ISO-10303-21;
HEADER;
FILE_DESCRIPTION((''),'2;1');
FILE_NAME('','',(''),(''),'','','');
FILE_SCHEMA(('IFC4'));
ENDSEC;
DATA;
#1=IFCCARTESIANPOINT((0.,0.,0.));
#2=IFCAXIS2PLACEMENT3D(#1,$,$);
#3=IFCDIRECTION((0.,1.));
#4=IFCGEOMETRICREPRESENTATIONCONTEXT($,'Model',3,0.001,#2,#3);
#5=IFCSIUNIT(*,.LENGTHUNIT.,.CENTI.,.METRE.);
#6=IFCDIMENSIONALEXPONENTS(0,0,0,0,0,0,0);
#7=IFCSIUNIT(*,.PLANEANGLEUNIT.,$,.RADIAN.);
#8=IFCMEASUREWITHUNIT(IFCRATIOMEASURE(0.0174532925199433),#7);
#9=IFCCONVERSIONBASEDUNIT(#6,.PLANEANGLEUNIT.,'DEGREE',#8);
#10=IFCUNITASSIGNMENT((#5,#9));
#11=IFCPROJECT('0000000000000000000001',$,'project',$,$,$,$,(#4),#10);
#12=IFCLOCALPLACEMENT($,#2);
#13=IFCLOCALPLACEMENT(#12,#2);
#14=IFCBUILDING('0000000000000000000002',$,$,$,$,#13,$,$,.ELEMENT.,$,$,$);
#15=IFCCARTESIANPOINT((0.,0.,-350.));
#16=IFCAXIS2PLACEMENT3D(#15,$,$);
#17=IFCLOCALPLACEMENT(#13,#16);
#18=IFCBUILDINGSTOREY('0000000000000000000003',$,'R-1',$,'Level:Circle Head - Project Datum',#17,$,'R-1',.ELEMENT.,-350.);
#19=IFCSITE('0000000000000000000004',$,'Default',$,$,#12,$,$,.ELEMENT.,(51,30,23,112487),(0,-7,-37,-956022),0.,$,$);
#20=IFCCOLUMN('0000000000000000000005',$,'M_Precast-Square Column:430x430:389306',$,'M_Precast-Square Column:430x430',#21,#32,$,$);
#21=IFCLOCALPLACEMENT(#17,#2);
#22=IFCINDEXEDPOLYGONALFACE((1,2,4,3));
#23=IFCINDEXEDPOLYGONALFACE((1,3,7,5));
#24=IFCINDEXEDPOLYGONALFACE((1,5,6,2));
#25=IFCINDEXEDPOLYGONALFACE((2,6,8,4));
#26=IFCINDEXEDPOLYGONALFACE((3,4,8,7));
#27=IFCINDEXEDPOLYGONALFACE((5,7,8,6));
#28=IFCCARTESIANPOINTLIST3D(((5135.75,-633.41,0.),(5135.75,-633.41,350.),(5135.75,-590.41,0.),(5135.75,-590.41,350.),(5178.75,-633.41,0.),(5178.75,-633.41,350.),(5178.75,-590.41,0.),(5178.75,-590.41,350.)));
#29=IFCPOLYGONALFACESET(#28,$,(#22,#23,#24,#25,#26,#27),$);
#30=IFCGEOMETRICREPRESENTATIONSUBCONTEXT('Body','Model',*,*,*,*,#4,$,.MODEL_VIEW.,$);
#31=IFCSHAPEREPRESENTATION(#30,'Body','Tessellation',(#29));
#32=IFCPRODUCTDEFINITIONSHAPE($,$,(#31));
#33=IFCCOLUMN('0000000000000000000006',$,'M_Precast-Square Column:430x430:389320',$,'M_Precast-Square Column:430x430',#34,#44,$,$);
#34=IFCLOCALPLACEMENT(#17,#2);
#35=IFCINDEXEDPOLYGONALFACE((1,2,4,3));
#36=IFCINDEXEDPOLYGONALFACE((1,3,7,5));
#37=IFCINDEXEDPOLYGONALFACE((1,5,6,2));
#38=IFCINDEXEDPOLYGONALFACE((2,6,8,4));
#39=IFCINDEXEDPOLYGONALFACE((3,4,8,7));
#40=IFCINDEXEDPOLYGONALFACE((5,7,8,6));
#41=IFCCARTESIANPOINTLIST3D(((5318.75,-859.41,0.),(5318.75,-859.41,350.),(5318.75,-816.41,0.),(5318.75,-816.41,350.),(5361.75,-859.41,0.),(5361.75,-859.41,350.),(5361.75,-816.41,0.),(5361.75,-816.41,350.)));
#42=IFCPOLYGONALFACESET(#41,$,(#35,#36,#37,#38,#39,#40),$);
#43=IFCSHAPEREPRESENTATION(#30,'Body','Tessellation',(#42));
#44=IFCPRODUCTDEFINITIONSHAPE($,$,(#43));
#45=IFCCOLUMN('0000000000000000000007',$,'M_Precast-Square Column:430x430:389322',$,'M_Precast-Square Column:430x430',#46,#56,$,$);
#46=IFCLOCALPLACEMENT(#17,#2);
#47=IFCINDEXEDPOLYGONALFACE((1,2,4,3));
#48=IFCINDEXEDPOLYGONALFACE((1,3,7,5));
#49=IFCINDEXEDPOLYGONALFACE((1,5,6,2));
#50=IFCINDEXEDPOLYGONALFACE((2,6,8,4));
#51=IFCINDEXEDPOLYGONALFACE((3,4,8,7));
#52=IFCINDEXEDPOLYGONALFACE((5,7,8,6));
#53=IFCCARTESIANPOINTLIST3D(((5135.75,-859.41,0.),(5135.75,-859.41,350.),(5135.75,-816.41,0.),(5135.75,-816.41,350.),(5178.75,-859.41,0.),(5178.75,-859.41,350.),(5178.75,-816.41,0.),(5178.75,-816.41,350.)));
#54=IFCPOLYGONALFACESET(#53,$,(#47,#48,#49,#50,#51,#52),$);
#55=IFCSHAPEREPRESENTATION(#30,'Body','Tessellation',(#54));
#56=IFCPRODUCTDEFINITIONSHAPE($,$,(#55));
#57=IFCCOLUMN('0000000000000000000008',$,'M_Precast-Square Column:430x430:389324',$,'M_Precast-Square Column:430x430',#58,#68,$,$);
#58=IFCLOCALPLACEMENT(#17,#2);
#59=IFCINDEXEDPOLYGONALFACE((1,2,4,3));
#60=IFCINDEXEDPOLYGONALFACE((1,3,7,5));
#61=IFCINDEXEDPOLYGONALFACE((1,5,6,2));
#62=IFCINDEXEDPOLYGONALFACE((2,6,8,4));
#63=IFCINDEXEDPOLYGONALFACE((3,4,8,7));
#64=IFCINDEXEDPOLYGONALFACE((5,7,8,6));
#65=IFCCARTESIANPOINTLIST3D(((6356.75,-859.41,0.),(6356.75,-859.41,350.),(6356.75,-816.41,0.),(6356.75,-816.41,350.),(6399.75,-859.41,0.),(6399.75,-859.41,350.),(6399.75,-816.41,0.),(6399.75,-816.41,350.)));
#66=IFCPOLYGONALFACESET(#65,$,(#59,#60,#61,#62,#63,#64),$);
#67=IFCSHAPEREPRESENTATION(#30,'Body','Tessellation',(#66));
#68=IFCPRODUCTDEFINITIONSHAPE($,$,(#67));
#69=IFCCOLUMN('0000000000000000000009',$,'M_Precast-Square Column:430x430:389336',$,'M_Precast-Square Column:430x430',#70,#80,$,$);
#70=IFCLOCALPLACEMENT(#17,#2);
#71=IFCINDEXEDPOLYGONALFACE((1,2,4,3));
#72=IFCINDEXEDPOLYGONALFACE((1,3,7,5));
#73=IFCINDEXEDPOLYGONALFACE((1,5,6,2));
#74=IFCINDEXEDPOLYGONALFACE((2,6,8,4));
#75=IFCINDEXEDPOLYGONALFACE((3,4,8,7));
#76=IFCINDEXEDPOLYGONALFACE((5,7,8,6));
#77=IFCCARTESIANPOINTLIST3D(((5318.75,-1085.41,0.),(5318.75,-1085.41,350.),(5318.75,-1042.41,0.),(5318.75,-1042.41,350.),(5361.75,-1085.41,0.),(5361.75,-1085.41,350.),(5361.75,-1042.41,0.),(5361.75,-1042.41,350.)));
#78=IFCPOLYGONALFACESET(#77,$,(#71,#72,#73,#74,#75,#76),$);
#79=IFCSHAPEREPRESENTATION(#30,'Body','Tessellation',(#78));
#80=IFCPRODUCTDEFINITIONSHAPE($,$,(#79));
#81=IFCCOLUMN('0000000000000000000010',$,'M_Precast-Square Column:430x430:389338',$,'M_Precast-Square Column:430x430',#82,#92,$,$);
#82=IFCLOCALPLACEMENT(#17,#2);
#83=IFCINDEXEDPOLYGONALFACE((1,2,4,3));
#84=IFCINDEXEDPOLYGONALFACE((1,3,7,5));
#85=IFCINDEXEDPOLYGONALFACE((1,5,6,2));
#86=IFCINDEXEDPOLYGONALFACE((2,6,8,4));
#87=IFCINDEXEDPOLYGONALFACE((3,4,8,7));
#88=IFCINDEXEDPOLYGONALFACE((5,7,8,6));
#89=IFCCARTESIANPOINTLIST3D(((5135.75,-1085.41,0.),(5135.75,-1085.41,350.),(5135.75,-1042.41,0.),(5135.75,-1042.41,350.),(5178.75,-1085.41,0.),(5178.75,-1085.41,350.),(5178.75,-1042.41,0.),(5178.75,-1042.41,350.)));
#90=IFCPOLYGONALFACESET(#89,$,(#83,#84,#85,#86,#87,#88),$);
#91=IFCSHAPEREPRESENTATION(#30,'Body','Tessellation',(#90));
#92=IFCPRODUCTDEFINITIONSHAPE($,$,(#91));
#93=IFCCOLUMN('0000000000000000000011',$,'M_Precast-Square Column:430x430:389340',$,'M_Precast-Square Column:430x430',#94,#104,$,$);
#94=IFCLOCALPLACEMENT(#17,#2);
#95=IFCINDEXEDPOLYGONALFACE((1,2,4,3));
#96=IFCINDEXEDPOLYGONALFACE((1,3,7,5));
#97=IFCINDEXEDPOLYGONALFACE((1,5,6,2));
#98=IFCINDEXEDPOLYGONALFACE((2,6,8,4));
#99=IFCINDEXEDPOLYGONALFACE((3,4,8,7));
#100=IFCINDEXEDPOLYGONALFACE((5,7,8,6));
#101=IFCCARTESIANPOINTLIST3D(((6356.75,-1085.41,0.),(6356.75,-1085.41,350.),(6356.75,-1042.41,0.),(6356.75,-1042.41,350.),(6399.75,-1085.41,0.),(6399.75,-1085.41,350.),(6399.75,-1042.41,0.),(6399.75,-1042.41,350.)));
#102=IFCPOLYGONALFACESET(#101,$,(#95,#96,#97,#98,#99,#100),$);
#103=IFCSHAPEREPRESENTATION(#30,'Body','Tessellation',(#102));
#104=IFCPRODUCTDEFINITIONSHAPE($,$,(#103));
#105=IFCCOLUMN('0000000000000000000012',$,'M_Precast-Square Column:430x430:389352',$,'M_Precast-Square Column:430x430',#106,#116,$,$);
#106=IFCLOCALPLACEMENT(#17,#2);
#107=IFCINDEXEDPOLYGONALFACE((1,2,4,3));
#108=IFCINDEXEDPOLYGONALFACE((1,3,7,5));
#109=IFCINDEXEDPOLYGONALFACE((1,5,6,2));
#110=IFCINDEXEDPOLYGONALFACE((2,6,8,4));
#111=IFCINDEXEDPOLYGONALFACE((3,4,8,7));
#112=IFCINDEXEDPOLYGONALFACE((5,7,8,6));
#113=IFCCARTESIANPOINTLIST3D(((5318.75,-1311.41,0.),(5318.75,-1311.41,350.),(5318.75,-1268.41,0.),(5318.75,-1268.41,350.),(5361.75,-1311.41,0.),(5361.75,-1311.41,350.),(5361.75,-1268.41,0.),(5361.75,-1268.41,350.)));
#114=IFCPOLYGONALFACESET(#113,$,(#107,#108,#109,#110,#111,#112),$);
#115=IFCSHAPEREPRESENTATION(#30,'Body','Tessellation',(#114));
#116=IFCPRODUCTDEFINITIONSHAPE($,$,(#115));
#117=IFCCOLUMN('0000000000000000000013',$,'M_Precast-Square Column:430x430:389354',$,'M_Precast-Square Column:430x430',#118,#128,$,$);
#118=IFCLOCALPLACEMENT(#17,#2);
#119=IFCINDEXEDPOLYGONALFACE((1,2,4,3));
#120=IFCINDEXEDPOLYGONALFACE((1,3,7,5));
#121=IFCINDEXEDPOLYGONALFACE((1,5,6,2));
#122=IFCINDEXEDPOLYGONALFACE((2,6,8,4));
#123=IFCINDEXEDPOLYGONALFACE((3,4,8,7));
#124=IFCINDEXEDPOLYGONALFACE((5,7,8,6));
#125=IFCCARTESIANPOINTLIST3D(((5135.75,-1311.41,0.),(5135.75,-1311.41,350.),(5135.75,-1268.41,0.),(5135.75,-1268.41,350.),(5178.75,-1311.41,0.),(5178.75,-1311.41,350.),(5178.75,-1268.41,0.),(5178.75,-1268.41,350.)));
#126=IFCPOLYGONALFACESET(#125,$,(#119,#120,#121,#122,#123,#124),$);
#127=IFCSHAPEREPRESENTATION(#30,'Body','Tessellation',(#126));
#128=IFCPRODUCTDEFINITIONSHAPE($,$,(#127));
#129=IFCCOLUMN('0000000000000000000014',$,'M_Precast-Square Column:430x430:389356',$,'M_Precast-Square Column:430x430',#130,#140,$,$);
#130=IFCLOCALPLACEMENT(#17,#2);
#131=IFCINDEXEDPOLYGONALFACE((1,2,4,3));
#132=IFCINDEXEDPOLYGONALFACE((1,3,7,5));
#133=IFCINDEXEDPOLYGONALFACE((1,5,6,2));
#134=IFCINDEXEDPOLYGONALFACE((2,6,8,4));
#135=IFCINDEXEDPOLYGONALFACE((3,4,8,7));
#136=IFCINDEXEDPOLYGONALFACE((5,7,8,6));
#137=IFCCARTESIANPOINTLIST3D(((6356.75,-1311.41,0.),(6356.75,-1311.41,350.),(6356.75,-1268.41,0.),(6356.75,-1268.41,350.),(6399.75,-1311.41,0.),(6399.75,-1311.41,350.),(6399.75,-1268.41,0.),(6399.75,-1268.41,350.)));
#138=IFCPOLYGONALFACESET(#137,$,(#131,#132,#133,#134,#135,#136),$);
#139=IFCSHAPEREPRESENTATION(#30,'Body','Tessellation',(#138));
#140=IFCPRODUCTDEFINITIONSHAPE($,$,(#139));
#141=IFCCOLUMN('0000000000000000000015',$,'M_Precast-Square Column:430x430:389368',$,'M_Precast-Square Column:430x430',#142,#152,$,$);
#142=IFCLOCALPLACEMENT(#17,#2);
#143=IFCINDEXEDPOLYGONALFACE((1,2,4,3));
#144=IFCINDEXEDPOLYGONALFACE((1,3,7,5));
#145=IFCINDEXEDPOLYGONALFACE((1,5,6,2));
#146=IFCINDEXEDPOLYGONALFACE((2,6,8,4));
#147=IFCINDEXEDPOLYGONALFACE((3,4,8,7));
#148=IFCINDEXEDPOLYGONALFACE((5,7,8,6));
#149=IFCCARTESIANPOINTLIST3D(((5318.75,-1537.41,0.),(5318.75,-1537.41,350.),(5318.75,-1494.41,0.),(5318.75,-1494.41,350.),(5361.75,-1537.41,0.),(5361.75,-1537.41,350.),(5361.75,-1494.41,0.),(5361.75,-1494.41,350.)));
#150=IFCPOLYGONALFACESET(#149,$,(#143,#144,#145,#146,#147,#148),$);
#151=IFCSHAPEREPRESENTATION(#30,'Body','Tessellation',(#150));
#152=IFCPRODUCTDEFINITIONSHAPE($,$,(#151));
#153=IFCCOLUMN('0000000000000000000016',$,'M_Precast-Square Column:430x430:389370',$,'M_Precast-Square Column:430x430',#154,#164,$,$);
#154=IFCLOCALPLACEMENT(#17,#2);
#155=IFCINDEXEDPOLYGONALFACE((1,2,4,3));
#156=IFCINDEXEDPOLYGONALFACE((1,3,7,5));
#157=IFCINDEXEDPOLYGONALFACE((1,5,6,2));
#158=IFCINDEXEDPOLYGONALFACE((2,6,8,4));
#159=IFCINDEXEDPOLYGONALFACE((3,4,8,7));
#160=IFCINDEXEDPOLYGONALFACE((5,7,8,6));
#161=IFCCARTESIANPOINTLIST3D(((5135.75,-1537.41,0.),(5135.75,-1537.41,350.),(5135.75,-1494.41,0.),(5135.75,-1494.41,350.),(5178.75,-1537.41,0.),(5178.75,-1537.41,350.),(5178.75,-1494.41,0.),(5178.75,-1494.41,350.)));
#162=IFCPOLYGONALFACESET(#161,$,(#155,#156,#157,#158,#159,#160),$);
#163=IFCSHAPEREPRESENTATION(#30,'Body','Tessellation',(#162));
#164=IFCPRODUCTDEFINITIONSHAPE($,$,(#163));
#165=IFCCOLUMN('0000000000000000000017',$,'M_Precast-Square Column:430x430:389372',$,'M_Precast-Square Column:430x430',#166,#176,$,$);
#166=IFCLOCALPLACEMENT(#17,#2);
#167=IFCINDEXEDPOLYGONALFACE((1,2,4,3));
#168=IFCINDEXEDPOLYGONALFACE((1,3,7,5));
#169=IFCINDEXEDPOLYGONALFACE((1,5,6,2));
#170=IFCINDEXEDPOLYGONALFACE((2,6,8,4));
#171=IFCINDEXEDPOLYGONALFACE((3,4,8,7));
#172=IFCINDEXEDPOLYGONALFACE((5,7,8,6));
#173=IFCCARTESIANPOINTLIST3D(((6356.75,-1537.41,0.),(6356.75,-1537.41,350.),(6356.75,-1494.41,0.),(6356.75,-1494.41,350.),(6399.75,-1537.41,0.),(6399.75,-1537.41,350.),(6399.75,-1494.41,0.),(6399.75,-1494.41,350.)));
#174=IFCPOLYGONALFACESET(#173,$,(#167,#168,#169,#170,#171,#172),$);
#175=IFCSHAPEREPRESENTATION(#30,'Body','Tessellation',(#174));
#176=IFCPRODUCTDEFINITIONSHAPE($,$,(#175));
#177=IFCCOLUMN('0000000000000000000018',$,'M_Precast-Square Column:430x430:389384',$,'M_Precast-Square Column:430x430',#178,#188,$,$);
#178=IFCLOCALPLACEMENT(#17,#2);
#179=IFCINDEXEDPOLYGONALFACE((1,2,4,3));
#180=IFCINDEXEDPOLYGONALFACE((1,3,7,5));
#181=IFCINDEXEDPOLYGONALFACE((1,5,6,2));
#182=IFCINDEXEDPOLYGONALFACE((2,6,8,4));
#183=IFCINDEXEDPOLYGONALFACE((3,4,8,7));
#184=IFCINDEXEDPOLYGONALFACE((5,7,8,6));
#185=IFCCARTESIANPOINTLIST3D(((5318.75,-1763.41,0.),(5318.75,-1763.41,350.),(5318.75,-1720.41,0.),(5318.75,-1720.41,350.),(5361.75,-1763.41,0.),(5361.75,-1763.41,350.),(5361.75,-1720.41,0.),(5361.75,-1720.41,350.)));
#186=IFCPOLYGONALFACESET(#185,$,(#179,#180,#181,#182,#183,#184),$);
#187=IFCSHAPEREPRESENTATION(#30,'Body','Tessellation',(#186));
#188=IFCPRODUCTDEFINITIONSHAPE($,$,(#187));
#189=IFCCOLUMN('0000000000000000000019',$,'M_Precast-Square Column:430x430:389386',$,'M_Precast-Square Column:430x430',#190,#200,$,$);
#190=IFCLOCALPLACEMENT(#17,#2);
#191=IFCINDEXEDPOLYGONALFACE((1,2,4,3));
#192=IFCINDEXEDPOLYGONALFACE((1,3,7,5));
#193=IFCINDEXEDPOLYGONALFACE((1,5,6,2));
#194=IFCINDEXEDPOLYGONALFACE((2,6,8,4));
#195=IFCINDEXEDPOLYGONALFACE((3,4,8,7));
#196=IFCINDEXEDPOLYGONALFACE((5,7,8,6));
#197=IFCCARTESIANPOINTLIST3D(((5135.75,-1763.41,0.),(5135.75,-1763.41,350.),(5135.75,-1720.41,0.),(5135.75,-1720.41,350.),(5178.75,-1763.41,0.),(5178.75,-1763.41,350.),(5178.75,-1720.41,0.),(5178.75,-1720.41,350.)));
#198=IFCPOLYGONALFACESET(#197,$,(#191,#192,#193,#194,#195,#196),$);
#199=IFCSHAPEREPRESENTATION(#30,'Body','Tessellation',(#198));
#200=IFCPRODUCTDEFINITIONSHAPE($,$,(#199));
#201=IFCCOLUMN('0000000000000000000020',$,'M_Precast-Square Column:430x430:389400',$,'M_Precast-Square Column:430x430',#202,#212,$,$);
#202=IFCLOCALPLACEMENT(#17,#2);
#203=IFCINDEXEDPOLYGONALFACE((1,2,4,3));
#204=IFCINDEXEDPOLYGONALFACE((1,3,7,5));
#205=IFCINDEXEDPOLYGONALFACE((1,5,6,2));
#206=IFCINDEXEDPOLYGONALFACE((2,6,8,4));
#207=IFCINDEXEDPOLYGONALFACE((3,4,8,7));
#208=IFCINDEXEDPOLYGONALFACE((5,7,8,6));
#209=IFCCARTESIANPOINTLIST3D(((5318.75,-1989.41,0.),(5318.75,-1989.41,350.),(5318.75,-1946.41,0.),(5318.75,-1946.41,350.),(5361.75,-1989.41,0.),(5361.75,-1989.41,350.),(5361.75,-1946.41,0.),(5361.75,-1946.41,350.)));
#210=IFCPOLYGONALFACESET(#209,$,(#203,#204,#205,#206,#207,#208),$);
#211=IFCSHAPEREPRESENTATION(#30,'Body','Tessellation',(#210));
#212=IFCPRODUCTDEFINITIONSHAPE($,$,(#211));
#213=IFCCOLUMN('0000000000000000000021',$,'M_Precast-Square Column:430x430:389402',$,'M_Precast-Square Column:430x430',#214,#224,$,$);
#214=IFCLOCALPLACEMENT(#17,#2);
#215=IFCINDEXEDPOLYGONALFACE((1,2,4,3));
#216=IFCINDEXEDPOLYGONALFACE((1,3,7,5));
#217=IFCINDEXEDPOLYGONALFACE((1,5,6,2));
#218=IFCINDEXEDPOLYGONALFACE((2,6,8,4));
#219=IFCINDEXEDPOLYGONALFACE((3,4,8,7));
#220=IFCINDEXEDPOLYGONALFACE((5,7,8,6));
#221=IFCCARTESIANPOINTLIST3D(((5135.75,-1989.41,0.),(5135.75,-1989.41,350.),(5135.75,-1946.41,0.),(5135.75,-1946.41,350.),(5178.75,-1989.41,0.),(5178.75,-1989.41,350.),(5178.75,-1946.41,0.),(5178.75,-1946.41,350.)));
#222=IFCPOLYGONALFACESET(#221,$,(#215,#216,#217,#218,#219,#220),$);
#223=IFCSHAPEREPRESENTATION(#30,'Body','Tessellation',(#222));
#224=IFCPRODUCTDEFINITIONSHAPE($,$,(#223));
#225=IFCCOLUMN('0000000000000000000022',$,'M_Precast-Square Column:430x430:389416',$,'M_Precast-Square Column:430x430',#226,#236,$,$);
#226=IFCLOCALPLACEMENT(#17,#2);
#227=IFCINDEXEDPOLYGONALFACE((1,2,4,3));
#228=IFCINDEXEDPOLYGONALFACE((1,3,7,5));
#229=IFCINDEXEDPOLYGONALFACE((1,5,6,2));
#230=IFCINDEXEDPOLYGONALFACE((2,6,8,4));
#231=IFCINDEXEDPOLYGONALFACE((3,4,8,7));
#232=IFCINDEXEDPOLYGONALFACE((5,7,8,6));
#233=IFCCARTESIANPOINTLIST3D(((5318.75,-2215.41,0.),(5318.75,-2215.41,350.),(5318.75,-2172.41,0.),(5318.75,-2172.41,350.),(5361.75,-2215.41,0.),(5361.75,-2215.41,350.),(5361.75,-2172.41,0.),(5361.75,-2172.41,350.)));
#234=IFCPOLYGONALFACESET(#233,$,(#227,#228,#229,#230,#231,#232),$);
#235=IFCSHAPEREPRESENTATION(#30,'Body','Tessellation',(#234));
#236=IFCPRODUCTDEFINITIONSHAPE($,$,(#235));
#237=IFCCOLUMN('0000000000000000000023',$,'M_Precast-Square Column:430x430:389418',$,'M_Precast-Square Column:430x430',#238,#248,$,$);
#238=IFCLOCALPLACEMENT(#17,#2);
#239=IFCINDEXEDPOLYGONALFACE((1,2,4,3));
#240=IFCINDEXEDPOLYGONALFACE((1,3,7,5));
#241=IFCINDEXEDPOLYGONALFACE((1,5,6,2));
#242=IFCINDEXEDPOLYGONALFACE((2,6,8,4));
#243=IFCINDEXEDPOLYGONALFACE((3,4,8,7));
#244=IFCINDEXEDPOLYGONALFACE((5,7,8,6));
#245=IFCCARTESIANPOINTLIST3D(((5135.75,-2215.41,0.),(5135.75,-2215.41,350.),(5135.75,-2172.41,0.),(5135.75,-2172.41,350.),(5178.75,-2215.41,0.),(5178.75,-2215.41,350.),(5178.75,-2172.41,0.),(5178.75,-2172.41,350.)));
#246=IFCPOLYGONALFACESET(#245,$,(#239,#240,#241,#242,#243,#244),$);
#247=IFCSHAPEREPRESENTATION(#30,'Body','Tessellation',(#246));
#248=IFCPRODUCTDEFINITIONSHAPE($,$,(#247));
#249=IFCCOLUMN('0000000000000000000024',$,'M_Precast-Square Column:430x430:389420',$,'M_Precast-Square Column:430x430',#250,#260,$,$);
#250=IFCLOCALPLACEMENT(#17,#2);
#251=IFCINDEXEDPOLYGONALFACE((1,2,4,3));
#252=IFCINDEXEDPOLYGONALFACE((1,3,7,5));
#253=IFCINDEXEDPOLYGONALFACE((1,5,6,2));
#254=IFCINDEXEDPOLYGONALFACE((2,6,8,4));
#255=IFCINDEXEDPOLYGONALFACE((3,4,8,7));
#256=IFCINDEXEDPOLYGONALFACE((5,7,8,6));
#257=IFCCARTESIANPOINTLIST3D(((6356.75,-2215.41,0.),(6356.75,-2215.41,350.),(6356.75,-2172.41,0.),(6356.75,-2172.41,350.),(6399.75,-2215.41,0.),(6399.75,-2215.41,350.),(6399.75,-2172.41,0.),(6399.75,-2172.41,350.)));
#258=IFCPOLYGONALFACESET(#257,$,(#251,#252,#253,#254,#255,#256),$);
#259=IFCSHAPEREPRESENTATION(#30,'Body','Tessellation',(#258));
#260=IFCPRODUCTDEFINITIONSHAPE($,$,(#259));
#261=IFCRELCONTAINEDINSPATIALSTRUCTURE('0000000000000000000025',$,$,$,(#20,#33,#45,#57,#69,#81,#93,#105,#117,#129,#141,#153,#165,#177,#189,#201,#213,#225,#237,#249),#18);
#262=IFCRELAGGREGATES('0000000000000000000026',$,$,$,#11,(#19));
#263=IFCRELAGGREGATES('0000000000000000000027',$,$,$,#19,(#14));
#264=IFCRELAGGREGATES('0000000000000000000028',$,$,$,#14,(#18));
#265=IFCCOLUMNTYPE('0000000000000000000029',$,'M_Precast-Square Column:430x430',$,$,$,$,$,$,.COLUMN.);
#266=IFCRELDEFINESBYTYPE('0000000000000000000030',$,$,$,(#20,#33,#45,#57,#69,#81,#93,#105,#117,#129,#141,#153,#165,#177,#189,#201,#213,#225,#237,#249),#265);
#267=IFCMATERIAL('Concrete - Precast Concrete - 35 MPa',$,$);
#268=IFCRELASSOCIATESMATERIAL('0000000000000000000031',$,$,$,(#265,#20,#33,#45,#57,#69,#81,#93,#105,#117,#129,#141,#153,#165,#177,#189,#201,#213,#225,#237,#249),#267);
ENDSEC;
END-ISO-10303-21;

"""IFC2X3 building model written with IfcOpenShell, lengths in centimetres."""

from ifc_helpers import new_model, entity, si_unit, converted_unit, direction, frame, origin, origin_2d_with_axis, place, context, subcontext, project, spatial, rectangle, extrude, source, transform, mapped, material, type_object, type_shapes, element, save


model = new_model("IFC2X3")

# Units and contexts
model_context = context("Model", 3, precision=0.001, world=origin(), true_north=direction((0.0, 1.0)))
body_context = subcontext(model_context, "Body", "Model", "MODEL_VIEW")
ifc_project = project(units=[si_unit("LENGTHUNIT", "METRE", prefix="CENTI"), converted_unit("PLANEANGLEUNIT", "DEGREE", entity("IfcRatioMeasure", 0.0174532925199433), si_unit("PLANEANGLEUNIT", "RADIAN"), dimensions=[0, 0, 0, 0, 0, 0, 0])], contexts=[model_context])

# Site, building, storey
site_placement = place(None, origin())
site = spatial("IfcSite", under=ifc_project, at=site_placement, Name="Default", CompositionType="ELEMENT", RefLatitude=(51, 30, 23, 112487), RefLongitude=(0, -7, -37, -956022), RefElevation=0.0)
building_placement = place(site_placement, origin())
building = spatial("IfcBuilding", under=site, at=building_placement, CompositionType="ELEMENT")
storey_placement = place(building_placement, frame((0.0, 0.0, -350.0)))
storey = spatial("IfcBuildingStorey", under=building, at=storey_placement, Name="R-1", ObjectType="Level:Circle Head - Project Datum", LongName="R-1", CompositionType="ELEMENT", Elevation=-350.0)

# Columns
ifc_material_1 = material(Name="Concrete - Precast Concrete - 35 MPa")
column_type = type_object("IfcColumnType", Name="M_Precast-Square Column:430x430", PredefinedType="COLUMN", material=ifc_material_1)
shared_shape = source(origin(), body_context, "Body", "SweptSolid", [
    extrude(rectangle(XDim=43.0, YDim=43.0, at=origin_2d_with_axis()), frame((0.0, 0.0, -350.0), z_axis=(0.0, 0.0, 1.0), x_axis=(0.0, -1.0, 0.0)), (0.0, 0.0, 1.0), 350.0),
])
type_shapes(column_type, [shared_shape])
for number, where, name in (
    (1, (5157.25, -611.91, 350.0), "M_Precast-Square Column:430x430:389306"),
    (2, (5340.25, -837.91, 350.0), "M_Precast-Square Column:430x430:389320"),
    (3, (5157.25, -837.91, 350.0), "M_Precast-Square Column:430x430:389322"),
    (4, (6378.25, -837.91, 350.0), "M_Precast-Square Column:430x430:389324"),
    (5, (5340.25, -1063.91, 350.0), "M_Precast-Square Column:430x430:389336"),
    (6, (5157.25, -1063.91, 350.0), "M_Precast-Square Column:430x430:389338"),
    (7, (6378.25, -1063.91, 350.0), "M_Precast-Square Column:430x430:389340"),
    (8, (5340.25, -1289.91, 350.0), "M_Precast-Square Column:430x430:389352"),
    (9, (5157.25, -1289.91, 350.0), "M_Precast-Square Column:430x430:389354"),
    (10, (6378.25, -1289.91, 350.0), "M_Precast-Square Column:430x430:389356"),
    (11, (5340.25, -1515.91, 350.0), "M_Precast-Square Column:430x430:389368"),
    (12, (5157.25, -1515.91, 350.0), "M_Precast-Square Column:430x430:389370"),
    (13, (6378.25, -1515.91, 350.0), "M_Precast-Square Column:430x430:389372"),
    (14, (5340.25, -1741.91, 350.0), "M_Precast-Square Column:430x430:389384"),
    (15, (5157.25, -1741.91, 350.0), "M_Precast-Square Column:430x430:389386"),
    (16, (5340.25, -1967.91, 350.0), "M_Precast-Square Column:430x430:389400"),
    (17, (5157.25, -1967.91, 350.0), "M_Precast-Square Column:430x430:389402"),
    (18, (5340.25, -2193.91, 350.0), "M_Precast-Square Column:430x430:389416"),
    (19, (5157.25, -2193.91, 350.0), "M_Precast-Square Column:430x430:389418"),
    (20, (6378.25, -2193.91, 350.0), "M_Precast-Square Column:430x430:389420"),
):
    element("IfcColumn", number, at=place(storey_placement, frame(where)), inside=storey, type_object=column_type, material=ifc_material_1, Name=name, ObjectType="M_Precast-Square Column:430x430", context=body_context, shape_type="MappedRepresentation", body=[
        mapped(shared_shape, transform((0.0, 0.0, 0.0), scale=1.0)),
    ])

save(model, "model.ifc")
